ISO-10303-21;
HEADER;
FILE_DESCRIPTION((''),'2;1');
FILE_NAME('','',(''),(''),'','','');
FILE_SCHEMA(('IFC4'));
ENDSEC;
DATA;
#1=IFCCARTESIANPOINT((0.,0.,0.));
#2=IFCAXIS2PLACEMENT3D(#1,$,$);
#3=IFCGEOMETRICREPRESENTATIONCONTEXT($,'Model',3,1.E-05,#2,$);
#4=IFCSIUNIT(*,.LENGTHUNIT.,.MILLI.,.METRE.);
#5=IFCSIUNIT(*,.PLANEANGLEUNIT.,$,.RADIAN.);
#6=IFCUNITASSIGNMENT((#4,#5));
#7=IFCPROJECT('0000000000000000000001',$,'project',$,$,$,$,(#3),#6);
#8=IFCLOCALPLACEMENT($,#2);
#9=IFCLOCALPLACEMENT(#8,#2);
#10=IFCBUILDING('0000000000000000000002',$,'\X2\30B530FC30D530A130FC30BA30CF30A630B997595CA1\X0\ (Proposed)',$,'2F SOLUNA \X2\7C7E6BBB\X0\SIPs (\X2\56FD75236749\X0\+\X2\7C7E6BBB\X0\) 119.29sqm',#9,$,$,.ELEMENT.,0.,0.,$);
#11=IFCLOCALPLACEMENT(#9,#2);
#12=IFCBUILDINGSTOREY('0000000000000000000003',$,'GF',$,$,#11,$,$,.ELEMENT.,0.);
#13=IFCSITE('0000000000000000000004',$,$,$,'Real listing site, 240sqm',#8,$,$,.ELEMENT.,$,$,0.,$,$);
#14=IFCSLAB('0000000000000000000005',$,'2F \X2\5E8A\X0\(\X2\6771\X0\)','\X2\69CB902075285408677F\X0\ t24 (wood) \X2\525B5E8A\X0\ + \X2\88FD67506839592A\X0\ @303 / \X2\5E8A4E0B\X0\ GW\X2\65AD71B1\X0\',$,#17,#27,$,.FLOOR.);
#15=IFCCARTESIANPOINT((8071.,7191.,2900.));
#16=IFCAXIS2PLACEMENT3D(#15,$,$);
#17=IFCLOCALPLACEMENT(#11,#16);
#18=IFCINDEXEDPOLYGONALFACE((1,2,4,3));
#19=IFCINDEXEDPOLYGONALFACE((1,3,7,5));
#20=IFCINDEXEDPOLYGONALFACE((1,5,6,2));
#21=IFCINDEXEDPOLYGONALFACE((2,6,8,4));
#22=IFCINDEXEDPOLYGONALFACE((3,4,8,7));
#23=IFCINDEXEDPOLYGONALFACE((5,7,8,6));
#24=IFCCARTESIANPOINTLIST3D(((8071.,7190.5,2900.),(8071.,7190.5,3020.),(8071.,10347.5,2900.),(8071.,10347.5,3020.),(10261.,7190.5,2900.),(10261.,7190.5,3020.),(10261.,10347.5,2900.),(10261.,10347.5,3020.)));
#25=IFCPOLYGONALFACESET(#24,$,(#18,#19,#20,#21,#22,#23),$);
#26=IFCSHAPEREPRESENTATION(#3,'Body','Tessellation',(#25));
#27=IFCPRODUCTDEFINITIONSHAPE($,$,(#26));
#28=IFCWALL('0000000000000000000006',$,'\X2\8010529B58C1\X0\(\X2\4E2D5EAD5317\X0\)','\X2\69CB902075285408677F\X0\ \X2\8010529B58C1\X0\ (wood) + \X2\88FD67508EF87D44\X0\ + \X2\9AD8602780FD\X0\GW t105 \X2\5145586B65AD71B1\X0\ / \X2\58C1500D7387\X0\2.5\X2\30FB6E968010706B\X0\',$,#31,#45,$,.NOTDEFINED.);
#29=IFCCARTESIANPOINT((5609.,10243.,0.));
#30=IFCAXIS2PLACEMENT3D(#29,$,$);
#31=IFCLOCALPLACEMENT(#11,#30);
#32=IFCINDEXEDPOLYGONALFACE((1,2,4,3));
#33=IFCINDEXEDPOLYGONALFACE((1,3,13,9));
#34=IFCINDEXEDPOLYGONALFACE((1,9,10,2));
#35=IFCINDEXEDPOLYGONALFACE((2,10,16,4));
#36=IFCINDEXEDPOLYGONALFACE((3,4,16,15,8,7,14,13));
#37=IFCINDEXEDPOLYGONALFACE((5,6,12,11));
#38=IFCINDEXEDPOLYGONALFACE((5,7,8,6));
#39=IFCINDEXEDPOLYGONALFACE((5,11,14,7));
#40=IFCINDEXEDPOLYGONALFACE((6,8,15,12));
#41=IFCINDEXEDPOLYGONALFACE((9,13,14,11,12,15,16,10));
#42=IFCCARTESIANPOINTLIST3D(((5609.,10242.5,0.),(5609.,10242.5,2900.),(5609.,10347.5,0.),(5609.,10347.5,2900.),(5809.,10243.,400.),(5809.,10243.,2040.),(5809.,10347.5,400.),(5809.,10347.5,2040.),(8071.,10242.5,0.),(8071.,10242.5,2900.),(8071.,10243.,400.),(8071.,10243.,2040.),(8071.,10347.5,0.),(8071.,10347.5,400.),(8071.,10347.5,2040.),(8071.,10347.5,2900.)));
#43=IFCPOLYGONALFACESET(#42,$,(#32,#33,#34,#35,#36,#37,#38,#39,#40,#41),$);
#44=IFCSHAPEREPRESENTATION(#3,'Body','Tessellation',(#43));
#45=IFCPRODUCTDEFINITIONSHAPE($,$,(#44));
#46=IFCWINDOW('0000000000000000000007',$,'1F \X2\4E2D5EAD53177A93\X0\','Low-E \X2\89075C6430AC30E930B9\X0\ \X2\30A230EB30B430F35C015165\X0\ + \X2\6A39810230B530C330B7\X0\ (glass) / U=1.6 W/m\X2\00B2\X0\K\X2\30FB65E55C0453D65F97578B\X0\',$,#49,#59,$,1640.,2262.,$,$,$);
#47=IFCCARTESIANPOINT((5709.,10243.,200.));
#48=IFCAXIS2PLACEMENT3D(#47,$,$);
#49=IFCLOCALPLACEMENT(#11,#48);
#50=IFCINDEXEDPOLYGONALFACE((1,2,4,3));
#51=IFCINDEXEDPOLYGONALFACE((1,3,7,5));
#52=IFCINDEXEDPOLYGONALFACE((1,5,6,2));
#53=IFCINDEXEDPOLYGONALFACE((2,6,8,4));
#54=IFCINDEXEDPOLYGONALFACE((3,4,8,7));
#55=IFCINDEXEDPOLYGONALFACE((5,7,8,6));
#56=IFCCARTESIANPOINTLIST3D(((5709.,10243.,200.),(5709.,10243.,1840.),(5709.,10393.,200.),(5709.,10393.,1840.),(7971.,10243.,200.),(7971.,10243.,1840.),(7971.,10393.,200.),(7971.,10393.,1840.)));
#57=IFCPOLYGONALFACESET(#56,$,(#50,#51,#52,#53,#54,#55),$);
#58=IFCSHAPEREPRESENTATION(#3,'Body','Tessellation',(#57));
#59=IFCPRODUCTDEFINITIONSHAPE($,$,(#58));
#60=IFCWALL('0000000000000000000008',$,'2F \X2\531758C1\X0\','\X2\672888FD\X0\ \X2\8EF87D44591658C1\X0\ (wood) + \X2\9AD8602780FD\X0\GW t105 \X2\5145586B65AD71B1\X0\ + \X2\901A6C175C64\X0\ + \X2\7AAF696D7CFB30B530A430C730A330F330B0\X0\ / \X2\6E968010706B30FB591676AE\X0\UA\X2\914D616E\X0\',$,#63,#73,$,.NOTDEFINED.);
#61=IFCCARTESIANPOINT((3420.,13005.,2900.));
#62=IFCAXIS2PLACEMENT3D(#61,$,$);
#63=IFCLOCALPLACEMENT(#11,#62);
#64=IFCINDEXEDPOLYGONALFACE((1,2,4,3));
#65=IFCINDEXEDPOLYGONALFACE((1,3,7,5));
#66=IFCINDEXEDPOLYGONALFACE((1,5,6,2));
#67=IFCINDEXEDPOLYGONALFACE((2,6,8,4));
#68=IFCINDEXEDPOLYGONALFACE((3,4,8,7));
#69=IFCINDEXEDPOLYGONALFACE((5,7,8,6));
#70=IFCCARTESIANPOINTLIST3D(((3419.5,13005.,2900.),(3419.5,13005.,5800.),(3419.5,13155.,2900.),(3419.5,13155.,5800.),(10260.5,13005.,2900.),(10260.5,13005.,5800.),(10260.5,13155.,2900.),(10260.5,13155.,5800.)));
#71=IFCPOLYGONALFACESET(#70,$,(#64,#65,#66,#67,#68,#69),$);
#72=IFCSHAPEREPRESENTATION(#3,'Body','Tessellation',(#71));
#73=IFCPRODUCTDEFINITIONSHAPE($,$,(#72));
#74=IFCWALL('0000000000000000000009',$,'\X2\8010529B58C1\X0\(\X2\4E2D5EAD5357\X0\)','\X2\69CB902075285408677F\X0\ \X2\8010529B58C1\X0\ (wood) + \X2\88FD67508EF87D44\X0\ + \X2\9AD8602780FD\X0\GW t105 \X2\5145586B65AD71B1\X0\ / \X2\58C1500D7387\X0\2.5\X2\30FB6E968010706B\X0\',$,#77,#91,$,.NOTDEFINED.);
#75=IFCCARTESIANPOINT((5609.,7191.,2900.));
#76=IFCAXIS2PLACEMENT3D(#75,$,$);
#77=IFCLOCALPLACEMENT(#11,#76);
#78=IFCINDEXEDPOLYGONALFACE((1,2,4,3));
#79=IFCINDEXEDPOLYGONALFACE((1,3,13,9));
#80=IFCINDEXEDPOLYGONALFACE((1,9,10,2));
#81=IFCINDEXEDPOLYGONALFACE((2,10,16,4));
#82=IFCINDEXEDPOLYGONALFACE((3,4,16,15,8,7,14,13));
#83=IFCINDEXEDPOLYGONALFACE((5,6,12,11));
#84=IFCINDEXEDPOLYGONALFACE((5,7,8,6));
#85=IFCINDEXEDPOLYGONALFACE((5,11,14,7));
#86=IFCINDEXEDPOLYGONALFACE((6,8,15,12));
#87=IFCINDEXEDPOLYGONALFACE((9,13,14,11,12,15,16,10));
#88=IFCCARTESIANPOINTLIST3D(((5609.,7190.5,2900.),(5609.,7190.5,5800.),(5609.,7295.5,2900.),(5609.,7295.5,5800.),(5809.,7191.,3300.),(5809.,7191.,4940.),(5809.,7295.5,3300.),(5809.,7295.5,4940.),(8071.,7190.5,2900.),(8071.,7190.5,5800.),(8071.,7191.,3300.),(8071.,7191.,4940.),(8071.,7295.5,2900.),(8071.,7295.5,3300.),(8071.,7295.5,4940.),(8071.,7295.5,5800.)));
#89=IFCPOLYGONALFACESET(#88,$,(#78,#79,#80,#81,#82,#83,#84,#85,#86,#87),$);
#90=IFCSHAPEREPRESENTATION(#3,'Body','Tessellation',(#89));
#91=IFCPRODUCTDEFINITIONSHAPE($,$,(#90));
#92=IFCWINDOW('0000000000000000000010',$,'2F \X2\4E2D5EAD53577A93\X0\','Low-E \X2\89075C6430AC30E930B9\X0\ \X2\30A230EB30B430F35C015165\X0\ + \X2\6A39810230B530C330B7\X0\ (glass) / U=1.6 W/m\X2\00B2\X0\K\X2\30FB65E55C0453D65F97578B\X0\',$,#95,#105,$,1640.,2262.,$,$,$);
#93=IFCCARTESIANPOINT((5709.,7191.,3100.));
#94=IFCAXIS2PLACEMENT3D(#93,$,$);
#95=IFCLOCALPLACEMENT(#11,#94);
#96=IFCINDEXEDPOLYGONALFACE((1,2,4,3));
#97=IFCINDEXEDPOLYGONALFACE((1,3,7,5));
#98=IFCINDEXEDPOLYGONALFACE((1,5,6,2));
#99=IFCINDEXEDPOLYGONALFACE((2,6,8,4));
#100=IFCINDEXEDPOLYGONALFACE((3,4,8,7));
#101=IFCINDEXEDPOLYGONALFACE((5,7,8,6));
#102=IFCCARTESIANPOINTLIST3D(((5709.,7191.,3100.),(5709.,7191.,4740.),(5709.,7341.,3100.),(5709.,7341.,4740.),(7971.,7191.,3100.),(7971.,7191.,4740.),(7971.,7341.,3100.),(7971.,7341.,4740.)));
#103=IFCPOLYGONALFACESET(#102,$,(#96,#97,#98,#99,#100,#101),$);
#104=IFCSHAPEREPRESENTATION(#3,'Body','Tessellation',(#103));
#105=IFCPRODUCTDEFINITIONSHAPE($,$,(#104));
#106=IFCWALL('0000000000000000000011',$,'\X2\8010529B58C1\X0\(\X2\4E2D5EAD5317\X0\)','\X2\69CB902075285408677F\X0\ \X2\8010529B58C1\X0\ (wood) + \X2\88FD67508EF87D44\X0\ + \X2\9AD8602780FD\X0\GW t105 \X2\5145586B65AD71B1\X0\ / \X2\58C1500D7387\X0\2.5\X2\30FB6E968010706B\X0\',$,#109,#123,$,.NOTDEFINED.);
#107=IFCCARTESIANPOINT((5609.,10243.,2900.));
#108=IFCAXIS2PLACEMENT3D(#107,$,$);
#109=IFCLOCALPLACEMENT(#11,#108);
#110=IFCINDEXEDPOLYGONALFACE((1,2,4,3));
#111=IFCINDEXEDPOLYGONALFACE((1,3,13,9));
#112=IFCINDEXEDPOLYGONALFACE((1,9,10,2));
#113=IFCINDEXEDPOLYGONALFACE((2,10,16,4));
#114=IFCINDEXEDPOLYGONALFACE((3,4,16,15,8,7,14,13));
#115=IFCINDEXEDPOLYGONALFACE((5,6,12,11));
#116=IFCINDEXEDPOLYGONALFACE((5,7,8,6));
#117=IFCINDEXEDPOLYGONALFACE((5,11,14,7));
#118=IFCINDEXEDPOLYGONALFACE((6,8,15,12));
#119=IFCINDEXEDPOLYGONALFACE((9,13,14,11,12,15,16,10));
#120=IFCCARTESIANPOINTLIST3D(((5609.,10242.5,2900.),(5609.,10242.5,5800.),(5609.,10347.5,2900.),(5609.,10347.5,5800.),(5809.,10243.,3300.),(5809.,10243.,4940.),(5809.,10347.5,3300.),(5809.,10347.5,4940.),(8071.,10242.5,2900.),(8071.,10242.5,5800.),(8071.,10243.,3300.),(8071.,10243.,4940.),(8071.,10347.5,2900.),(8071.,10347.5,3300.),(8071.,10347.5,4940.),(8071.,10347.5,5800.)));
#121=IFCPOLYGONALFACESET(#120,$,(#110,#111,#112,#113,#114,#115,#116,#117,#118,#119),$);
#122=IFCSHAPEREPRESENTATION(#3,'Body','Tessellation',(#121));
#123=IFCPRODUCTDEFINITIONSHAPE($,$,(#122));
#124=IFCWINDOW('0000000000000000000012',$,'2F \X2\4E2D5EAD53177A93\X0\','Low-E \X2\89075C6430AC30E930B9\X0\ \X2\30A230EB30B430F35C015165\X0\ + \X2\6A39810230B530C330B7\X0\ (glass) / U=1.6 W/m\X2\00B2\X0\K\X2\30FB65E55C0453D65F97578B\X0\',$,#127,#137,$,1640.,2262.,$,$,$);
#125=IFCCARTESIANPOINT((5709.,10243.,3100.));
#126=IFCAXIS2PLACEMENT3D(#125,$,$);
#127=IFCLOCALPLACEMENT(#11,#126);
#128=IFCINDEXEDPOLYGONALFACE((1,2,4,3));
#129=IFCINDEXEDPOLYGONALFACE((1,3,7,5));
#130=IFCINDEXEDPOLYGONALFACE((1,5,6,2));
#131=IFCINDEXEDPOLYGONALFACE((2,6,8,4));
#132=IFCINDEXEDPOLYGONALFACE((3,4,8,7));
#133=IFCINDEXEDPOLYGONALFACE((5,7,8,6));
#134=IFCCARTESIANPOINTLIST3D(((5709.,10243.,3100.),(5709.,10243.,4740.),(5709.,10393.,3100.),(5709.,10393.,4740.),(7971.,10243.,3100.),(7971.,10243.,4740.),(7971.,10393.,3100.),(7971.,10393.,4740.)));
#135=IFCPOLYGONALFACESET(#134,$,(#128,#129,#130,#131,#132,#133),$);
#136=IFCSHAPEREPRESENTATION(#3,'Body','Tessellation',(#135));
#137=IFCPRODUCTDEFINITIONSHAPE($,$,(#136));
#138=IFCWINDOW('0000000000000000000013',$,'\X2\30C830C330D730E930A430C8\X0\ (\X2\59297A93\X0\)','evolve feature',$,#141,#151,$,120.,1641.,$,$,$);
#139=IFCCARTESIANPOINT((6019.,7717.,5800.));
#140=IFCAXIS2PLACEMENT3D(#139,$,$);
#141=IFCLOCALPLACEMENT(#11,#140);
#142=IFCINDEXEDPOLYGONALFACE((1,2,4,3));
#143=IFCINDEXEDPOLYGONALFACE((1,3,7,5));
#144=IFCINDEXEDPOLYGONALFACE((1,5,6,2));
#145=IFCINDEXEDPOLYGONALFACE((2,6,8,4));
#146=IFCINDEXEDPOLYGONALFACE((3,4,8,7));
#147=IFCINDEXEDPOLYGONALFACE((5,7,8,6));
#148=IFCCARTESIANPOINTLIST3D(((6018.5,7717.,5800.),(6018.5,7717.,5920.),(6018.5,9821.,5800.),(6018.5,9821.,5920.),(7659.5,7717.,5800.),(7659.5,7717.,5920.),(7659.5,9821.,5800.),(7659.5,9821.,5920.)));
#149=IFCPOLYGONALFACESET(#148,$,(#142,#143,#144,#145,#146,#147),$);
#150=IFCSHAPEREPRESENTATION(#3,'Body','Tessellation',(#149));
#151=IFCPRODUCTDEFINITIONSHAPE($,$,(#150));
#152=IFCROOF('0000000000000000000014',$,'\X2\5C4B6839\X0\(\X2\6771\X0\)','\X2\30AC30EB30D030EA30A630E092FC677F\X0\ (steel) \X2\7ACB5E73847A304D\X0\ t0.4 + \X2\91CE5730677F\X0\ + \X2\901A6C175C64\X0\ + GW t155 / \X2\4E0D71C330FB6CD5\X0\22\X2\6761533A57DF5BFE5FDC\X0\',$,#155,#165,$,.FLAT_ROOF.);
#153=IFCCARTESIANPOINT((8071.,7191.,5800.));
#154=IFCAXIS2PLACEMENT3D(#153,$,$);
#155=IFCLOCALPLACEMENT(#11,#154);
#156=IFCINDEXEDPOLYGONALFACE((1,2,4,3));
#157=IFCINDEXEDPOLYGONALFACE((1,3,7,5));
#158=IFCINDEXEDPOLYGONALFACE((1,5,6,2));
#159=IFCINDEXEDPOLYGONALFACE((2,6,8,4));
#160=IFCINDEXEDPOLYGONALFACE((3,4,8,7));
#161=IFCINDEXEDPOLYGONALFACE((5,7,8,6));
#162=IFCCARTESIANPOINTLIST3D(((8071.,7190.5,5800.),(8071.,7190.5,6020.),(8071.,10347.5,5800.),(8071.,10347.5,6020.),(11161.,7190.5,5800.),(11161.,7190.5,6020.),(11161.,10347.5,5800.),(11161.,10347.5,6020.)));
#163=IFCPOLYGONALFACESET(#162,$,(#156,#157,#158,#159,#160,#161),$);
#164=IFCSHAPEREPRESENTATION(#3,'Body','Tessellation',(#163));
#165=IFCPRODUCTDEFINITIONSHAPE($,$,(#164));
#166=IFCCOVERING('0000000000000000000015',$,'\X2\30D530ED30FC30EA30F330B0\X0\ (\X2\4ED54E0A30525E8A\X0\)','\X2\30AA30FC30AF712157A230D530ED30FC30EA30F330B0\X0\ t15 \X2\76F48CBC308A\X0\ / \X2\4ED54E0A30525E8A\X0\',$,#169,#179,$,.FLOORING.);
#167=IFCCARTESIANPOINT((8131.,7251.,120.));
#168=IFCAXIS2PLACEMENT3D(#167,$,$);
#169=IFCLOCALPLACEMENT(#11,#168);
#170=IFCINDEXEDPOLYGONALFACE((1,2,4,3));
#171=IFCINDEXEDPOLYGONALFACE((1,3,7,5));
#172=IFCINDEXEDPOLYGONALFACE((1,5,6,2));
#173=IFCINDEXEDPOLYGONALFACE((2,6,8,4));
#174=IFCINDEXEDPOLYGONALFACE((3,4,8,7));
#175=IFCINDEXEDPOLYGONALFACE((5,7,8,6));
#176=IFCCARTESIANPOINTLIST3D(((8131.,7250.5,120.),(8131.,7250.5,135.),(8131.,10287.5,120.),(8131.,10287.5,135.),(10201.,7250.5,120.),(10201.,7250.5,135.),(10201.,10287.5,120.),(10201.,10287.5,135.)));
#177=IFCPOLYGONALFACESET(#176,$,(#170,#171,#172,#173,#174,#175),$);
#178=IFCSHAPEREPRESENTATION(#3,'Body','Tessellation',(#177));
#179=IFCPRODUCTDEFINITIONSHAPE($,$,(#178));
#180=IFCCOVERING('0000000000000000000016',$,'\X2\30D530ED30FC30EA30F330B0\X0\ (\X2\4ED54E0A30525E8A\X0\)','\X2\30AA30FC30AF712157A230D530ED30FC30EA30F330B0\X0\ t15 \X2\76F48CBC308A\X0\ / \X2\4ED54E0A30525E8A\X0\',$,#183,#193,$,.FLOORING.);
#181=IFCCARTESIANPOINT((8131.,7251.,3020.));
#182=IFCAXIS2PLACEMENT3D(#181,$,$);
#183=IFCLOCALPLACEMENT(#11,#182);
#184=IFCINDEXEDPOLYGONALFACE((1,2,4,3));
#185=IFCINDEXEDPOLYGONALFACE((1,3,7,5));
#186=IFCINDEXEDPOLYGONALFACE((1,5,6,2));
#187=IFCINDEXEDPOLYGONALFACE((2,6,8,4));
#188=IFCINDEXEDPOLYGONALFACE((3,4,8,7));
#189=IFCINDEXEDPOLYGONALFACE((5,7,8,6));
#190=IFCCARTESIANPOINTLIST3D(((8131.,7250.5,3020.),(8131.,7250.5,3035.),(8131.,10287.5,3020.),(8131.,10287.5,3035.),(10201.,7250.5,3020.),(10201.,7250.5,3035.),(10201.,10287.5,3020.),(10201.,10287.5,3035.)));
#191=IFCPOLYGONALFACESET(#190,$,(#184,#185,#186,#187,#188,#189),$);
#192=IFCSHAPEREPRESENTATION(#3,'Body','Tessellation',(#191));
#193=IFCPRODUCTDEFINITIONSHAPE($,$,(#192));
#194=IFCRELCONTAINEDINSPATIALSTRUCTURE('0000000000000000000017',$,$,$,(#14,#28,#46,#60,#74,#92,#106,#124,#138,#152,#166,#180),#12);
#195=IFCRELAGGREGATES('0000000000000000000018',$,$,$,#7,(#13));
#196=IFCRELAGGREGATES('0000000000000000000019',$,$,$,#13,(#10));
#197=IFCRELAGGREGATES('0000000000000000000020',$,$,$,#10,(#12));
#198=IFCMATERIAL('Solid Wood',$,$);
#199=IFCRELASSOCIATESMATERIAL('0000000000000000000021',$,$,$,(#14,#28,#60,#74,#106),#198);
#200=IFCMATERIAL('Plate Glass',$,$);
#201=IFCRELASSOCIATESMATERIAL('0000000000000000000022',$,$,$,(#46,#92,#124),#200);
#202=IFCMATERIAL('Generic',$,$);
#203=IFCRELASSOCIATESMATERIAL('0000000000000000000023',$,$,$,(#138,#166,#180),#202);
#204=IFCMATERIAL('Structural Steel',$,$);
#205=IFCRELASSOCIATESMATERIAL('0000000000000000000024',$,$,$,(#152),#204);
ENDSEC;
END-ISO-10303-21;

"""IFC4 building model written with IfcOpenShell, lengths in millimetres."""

from ifc_helpers import new_model, si_unit, frame, frame_2d, origin, place, context, project, spatial, rectangle, extrude, material, element, fill, save


model = new_model("IFC4")

# Units and contexts
model_context = context("Model", 3, precision=1e-05, world=origin())
ifc_project = project(units=[si_unit("LENGTHUNIT", "METRE", prefix="MILLI"), si_unit("PLANEANGLEUNIT", "RADIAN")], contexts=[model_context])

# Site, building, storey
site_placement = place(None, origin())
site = spatial("IfcSite", under=ifc_project, at=site_placement, ObjectType="Real listing site, 240sqm", CompositionType="ELEMENT", RefElevation=0.0)
building_placement = place(site_placement, origin())
building = spatial("IfcBuilding", under=site, at=building_placement, Name="サーファーズハウス静岡 (Proposed)", ObjectType="2F SOLUNA 籾殻SIPs (国産杉+籾殻) 119.29sqm", CompositionType="ELEMENT", ElevationOfRefHeight=0.0, ElevationOfTerrain=0.0)
storey_placement = place(building_placement, origin())
storey = spatial("IfcBuildingStorey", under=building, at=storey_placement, Name="GF", CompositionType="ELEMENT", Elevation=0.0)

# Slab
ifc_material_1 = material(Name="Solid Wood")
slab_1_placement = place(storey_placement, frame((8071.0, 7191.0, 2900.0)))
element("IfcSlab", 1, at=slab_1_placement, inside=storey, material=ifc_material_1, Name="2F 床(東)", Description="構造用合板 t24 (wood) 剛床 + 製材根太 @303 / 床下 GW断熱", PredefinedType="FLOOR", context=model_context, shape_type="SweptSolid", body=[
    extrude(rectangle(XDim=2190.0, YDim=3157.0, at=frame_2d((1095.0, 1578.0))), frame((8071.0, 7191.0, 2900.0)), (0.0, 0.0, 1.0), 120.0),
])

# Wall, opening, window
wall_1_placement = place(storey_placement, frame((5609.0, 10243.0, 0.0)))
wall_1 = element("IfcWall", 2, at=wall_1_placement, inside=storey, material=ifc_material_1, Name="耐力壁(中庭北)", Description="構造用合板 耐力壁 (wood) + 製材軸組 + 高性能GW t105 充填断熱 / 壁倍率2.5・準耐火", PredefinedType="NOTDEFINED", context=model_context, shape_type="SweptSolid", body=[
    extrude(rectangle(XDim=2462.0, YDim=105.0, at=frame_2d((1231.0, 52.0))), frame((5609.0, 10243.0, 0.0)), (0.0, 0.0, 1.0), 2900.0),
])
opening_1_placement = place(storey_placement, frame((5709.0, 10243.0, 200.0)))
opening_1 = element("IfcOpeningElement", 3, at=opening_1_placement, cuts=wall_1, PredefinedType="NOTDEFINED", context=model_context, shape_type="SweptSolid", body=[
    extrude(rectangle(XDim=2262.0, YDim=150.0, at=frame_2d((1131.0, 75.0))), frame((5709.0, 10243.0, 200.0)), (0.0, 0.0, 1.0), 1640.0),
])
ifc_material_2 = material(Name="Plate Glass")
window_1_placement = place(storey_placement, frame((5709.0, 10243.0, 200.0)))
window_1 = element("IfcWindow", 4, at=window_1_placement, inside=storey, material=ifc_material_2, Name="1F 中庭北窓", Description="Low-E 複層ガラス アルゴン封入 + 樹脂サッシ (glass) / U=1.6 W/m²K・日射取得型", OverallHeight=1640.0, OverallWidth=2262.0, context=model_context, shape_type="SweptSolid", body=[
    extrude(rectangle(XDim=2262.0, YDim=150.0, at=frame_2d((1131.0, 75.0))), frame((5709.0, 10243.0, 200.0)), (0.0, 0.0, 1.0), 1640.0),
])
fill(opening_1, window_1)

# Wall
wall_2_placement = place(storey_placement, frame((3420.0, 13005.0, 2900.0)))
element("IfcWall", 5, at=wall_2_placement, inside=storey, material=ifc_material_1, Name="2F 北壁", Description="木製 軸組外壁 (wood) + 高性能GW t105 充填断熱 + 通気層 + 窯業系サイディング / 準耐火・外皮UA配慮", PredefinedType="NOTDEFINED", context=model_context, shape_type="SweptSolid", body=[
    extrude(rectangle(XDim=6841.0, YDim=150.0, at=frame_2d((3420.0, 75.0))), frame((3420.0, 13005.0, 2900.0)), (0.0, 0.0, 1.0), 2900.0),
])

# Walls, openings, windows
wall_3_placement = place(storey_placement, frame((5609.0, 7191.0, 2900.0)))
wall_3 = element("IfcWall", 6, at=wall_3_placement, inside=storey, material=ifc_material_1, Name="耐力壁(中庭南)", Description="構造用合板 耐力壁 (wood) + 製材軸組 + 高性能GW t105 充填断熱 / 壁倍率2.5・準耐火", PredefinedType="NOTDEFINED", context=model_context, shape_type="SweptSolid", body=[
    extrude(rectangle(XDim=2462.0, YDim=105.0, at=frame_2d((1231.0, 52.0))), frame((5609.0, 7191.0, 2900.0)), (0.0, 0.0, 1.0), 2900.0),
])
opening_2_placement = place(storey_placement, frame((5709.0, 7191.0, 3100.0)))
opening_2 = element("IfcOpeningElement", 7, at=opening_2_placement, cuts=wall_3, PredefinedType="NOTDEFINED", context=model_context, shape_type="SweptSolid", body=[
    extrude(rectangle(XDim=2262.0, YDim=150.0, at=frame_2d((1131.0, 75.0))), frame((5709.0, 7191.0, 3100.0)), (0.0, 0.0, 1.0), 1640.0),
])
window_2_placement = place(storey_placement, frame((5709.0, 7191.0, 3100.0)))
window_2 = element("IfcWindow", 8, at=window_2_placement, inside=storey, material=ifc_material_2, Name="2F 中庭南窓", Description="Low-E 複層ガラス アルゴン封入 + 樹脂サッシ (glass) / U=1.6 W/m²K・日射取得型", OverallHeight=1640.0, OverallWidth=2262.0, context=model_context, shape_type="SweptSolid", body=[
    extrude(rectangle(XDim=2262.0, YDim=150.0, at=frame_2d((1131.0, 75.0))), frame((5709.0, 7191.0, 3100.0)), (0.0, 0.0, 1.0), 1640.0),
])
fill(opening_2, window_2)
wall_4_placement = place(storey_placement, frame((5609.0, 10243.0, 2900.0)))
wall_4 = element("IfcWall", 9, at=wall_4_placement, inside=storey, material=ifc_material_1, Name="耐力壁(中庭北)", Description="構造用合板 耐力壁 (wood) + 製材軸組 + 高性能GW t105 充填断熱 / 壁倍率2.5・準耐火", PredefinedType="NOTDEFINED", context=model_context, shape_type="SweptSolid", body=[
    extrude(rectangle(XDim=2462.0, YDim=105.0, at=frame_2d((1231.0, 52.0))), frame((5609.0, 10243.0, 2900.0)), (0.0, 0.0, 1.0), 2900.0),
])
opening_3_placement = place(storey_placement, frame((5709.0, 10243.0, 3100.0)))
opening_3 = element("IfcOpeningElement", 10, at=opening_3_placement, cuts=wall_4, PredefinedType="NOTDEFINED", context=model_context, shape_type="SweptSolid", body=[
    extrude(rectangle(XDim=2262.0, YDim=150.0, at=frame_2d((1131.0, 75.0))), frame((5709.0, 10243.0, 3100.0)), (0.0, 0.0, 1.0), 1640.0),
])
window_3_placement = place(storey_placement, frame((5709.0, 10243.0, 3100.0)))
window_3 = element("IfcWindow", 11, at=window_3_placement, inside=storey, material=ifc_material_2, Name="2F 中庭北窓", Description="Low-E 複層ガラス アルゴン封入 + 樹脂サッシ (glass) / U=1.6 W/m²K・日射取得型", OverallHeight=1640.0, OverallWidth=2262.0, context=model_context, shape_type="SweptSolid", body=[
    extrude(rectangle(XDim=2262.0, YDim=150.0, at=frame_2d((1131.0, 75.0))), frame((5709.0, 10243.0, 3100.0)), (0.0, 0.0, 1.0), 1640.0),
])
fill(opening_3, window_3)

# Window
ifc_material_3 = material(Name="Generic")
window_4_placement = place(storey_placement, frame((6019.0, 7717.0, 5800.0)))
element("IfcWindow", 12, at=window_4_placement, inside=storey, material=ifc_material_3, Name="トップライト (天窓)", Description="evolve feature", OverallHeight=120.0, OverallWidth=1641.0, context=model_context, shape_type="SweptSolid", body=[
    extrude(rectangle(XDim=1641.0, YDim=2104.0, at=frame_2d((820.0, 1052.0))), frame((6019.0, 7717.0, 5800.0)), (0.0, 0.0, 1.0), 120.0),
])

# Roof
ifc_material_4 = material(Name="Structural Steel")
roof_1_placement = place(storey_placement, frame((8071.0, 7191.0, 5800.0)))
element("IfcRoof", 13, at=roof_1_placement, inside=storey, material=ifc_material_4, Name="屋根(東)", Description="ガルバリウム鋼板 (steel) 立平葺き t0.4 + 野地板 + 通気層 + GW t155 / 不燃・法22条区域対応", PredefinedType="FLAT_ROOF", context=model_context, shape_type="SweptSolid", body=[
    extrude(rectangle(XDim=3090.0, YDim=3157.0, at=frame_2d((1545.0, 1578.0))), frame((8071.0, 7191.0, 5800.0)), (0.0, 0.0, 1.0), 220.0),
])

# Coverings
covering_1_placement = place(storey_placement, frame((8131.0, 7251.0, 120.0)))
element("IfcCovering", 14, at=covering_1_placement, inside=storey, material=ifc_material_3, Name="フローリング (仕上げ床)", Description="オーク無垢フローリング t15 直貼り / 仕上げ床", PredefinedType="FLOORING", context=model_context, shape_type="SweptSolid", body=[
    extrude(rectangle(XDim=2070.0, YDim=3037.0, at=frame_2d((1035.0, 1518.0))), frame((8131.0, 7251.0, 120.0)), (0.0, 0.0, 1.0), 15.0),
])
covering_2_placement = place(storey_placement, frame((8131.0, 7251.0, 3020.0)))
element("IfcCovering", 15, at=covering_2_placement, inside=storey, material=ifc_material_3, Name="フローリング (仕上げ床)", Description="オーク無垢フローリング t15 直貼り / 仕上げ床", PredefinedType="FLOORING", context=model_context, shape_type="SweptSolid", body=[
    extrude(rectangle(XDim=2070.0, YDim=3037.0, at=frame_2d((1035.0, 1518.0))), frame((8131.0, 7251.0, 3020.0)), (0.0, 0.0, 1.0), 15.0),
])

save(model, "model.ifc")
